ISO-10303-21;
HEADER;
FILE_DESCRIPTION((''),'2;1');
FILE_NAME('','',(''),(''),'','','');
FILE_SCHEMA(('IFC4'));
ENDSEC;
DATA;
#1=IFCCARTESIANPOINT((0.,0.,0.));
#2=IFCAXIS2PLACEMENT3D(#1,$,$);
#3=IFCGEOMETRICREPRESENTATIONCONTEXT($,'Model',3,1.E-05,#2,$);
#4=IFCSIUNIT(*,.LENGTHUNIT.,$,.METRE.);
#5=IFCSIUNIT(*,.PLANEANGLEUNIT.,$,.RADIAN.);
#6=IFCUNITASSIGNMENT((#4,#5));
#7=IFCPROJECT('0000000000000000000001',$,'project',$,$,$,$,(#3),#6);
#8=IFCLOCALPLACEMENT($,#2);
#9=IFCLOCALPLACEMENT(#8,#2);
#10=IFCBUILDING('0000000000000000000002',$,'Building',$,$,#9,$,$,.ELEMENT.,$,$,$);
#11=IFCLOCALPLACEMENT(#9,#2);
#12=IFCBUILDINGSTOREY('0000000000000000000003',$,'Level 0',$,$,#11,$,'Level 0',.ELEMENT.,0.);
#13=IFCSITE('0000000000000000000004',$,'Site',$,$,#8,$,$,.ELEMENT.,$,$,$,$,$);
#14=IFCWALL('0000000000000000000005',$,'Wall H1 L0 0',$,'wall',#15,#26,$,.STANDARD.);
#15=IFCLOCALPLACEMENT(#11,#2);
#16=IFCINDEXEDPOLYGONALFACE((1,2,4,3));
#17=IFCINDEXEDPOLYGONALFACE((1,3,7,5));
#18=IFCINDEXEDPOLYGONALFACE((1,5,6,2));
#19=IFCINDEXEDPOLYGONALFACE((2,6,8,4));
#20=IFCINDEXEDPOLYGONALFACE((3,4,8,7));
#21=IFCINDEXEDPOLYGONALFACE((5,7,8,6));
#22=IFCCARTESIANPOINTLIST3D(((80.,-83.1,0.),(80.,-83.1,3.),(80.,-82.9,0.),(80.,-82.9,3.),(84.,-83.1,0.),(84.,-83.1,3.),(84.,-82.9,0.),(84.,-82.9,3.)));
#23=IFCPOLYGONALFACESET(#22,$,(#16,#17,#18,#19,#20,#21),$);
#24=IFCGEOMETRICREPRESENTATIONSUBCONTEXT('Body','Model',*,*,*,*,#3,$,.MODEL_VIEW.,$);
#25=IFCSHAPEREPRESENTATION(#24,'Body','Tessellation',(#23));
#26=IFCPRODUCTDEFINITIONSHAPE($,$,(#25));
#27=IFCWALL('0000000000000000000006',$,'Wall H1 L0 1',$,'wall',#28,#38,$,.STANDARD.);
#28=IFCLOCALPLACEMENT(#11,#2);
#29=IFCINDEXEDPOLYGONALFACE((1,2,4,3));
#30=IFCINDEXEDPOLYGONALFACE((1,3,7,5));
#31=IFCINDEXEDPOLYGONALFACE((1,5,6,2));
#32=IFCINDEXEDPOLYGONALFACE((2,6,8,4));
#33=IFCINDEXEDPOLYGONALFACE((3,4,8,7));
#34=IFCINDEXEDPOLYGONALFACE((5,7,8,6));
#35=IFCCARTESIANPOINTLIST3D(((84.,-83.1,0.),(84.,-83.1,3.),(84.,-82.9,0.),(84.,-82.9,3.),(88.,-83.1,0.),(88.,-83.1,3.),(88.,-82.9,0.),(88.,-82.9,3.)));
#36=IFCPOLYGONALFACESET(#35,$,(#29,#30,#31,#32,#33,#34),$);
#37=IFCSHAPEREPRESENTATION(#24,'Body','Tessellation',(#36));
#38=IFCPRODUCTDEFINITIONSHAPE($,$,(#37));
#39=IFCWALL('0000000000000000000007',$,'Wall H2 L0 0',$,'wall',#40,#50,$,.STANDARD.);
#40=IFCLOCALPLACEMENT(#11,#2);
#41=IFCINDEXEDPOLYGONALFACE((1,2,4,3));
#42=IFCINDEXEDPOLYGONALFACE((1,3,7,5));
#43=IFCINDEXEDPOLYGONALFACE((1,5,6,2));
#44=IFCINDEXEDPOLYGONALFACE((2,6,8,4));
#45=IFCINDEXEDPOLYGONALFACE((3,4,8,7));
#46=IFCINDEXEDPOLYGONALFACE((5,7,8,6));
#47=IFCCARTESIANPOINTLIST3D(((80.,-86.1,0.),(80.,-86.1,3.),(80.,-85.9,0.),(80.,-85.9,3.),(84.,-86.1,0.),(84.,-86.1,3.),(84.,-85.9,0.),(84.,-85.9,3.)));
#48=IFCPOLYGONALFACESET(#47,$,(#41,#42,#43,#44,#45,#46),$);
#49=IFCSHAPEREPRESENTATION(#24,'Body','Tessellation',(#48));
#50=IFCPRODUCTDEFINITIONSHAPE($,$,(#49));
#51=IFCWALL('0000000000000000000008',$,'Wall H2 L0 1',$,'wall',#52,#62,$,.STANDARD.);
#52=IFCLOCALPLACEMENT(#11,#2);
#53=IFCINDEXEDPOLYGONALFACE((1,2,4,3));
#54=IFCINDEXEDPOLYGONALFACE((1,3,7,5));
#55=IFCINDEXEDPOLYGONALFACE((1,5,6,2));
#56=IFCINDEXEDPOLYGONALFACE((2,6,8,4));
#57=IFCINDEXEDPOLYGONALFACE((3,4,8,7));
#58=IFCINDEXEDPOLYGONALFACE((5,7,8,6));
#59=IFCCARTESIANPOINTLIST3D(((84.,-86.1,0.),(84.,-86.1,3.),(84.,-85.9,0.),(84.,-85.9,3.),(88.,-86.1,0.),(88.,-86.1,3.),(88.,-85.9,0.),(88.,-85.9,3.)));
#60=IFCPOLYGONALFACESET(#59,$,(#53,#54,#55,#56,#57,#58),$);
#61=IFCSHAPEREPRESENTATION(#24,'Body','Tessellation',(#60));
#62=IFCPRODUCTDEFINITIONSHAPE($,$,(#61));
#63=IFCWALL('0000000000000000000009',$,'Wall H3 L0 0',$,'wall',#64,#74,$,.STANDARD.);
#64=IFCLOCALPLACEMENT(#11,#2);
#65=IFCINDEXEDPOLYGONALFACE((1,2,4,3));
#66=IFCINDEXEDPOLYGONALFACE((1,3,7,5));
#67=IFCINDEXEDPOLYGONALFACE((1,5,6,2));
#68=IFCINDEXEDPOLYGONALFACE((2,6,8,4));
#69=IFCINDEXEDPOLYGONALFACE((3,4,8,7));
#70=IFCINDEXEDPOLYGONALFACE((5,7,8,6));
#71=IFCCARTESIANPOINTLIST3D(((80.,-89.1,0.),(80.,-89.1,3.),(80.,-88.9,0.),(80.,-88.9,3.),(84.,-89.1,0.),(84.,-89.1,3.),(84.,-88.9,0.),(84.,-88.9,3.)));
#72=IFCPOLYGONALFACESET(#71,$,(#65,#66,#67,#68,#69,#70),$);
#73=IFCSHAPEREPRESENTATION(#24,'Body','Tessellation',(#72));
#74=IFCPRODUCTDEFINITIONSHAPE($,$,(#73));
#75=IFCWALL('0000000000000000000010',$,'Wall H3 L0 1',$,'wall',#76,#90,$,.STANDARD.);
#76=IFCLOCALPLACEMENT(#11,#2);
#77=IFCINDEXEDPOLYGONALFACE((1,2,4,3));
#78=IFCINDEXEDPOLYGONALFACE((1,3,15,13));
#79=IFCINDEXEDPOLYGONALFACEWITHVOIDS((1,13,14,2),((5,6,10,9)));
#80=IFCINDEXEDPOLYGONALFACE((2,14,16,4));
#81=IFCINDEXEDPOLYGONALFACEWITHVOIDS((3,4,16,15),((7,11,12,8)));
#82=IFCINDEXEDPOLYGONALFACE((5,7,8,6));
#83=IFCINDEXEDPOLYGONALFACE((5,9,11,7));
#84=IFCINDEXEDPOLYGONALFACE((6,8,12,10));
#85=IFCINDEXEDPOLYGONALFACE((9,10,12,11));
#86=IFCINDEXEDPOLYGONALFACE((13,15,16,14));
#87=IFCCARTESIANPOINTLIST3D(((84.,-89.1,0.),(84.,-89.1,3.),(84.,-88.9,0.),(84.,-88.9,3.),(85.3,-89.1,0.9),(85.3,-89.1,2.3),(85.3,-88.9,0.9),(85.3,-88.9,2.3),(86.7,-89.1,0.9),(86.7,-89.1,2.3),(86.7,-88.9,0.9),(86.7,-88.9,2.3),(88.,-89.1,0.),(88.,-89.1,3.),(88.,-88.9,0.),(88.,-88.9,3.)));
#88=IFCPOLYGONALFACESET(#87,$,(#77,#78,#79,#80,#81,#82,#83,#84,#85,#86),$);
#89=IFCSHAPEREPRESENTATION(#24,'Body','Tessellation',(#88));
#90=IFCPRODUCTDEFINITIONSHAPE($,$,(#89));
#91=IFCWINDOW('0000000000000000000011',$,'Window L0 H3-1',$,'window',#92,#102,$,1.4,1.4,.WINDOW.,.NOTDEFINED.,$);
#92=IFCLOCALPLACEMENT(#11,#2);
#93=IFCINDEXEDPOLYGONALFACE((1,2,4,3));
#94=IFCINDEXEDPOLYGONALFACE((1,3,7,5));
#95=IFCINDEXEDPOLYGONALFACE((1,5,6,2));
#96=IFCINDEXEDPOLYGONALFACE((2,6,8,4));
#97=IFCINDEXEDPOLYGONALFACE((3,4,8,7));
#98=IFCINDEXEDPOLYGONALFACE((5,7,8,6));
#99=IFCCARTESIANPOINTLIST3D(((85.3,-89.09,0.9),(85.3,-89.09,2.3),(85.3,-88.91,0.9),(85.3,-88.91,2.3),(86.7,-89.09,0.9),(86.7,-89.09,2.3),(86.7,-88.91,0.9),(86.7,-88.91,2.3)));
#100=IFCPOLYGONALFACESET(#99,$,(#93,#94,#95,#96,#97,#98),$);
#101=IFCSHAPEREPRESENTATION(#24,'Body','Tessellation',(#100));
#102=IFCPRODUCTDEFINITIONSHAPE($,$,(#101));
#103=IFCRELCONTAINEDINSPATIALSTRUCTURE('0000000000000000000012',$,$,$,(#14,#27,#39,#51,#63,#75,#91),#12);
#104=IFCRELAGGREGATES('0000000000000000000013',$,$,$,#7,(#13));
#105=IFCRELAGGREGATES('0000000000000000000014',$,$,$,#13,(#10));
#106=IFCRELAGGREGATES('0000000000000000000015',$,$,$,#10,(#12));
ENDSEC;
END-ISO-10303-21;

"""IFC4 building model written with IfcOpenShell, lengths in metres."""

from ifc_helpers import new_model, si_unit, frame, frame_2d, origin, origin_2d, place, context, subcontext, project, spatial, rectangle, extrude, element, fill, save


model = new_model("IFC4")

# Units and contexts
model_context = context("Model", 3, precision=1e-05, world=origin())
body_context = subcontext(model_context, "Body", "Model", "MODEL_VIEW")
ifc_project = project(units=[si_unit("LENGTHUNIT", "METRE"), si_unit("PLANEANGLEUNIT", "RADIAN")], contexts=[model_context])

# Site, building, storey
site_placement = place(None, origin())
site = spatial("IfcSite", under=ifc_project, at=site_placement, Name="Site", CompositionType="ELEMENT")
building_placement = place(site_placement, origin())
building = spatial("IfcBuilding", under=site, at=building_placement, Name="Building", CompositionType="ELEMENT")
storey_placement = place(building_placement, origin())
storey = spatial("IfcBuildingStorey", under=building, at=storey_placement, Name="Level 0", LongName="Level 0", CompositionType="ELEMENT", Elevation=0.0)

# Walls
for number, where, z_axis, x_axis, name in (
    (1, (80.0, -83.0, 0.0), (0.0, 0.0, 1.0), (1.0, 0.0, 0.0), "Wall H1 L0 0"),
    (2, (84.0, -83.0, 0.0), (0.0, 0.0, 1.0), (1.0, 0.0, 0.0), "Wall H1 L0 1"),
    (3, (80.0, -86.0, 0.0), (0.0, 0.0, 1.0), (1.0, 0.0, 0.0), "Wall H2 L0 0"),
    (4, (84.0, -86.0, 0.0), (0.0, 0.0, 1.0), (1.0, 0.0, 0.0), "Wall H2 L0 1"),
    (5, (80.0, -89.0, 0.0), (0.0, 0.0, 1.0), (1.0, 0.0, 0.0), "Wall H3 L0 0"),
):
    element("IfcWall", number, at=place(storey_placement, frame(where, z_axis=z_axis, x_axis=x_axis)), inside=storey, Name=name, ObjectType="wall", PredefinedType="STANDARD", context=body_context, shape_type="SweptSolid", body=[
        extrude(rectangle(XDim=4.0, YDim=0.2, at=frame_2d((2.0, 0.0))), origin(), (0.0, 0.0, 1.0), 3.0),
    ])

# Wall, opening, window
wall_1_placement = place(storey_placement, frame((84.0, -89.0, 0.0), z_axis=(0.0, 0.0, 1.0), x_axis=(1.0, 0.0, 0.0)))
wall_1 = element("IfcWall", 6, at=wall_1_placement, inside=storey, Name="Wall H3 L0 1", ObjectType="wall", PredefinedType="STANDARD", context=body_context, shape_type="SweptSolid", body=[
    extrude(rectangle(XDim=4.0, YDim=0.2, at=frame_2d((2.0, 0.0))), origin(), (0.0, 0.0, 1.0), 3.0),
])
opening_1_placement = place(storey_placement, frame((86.0, -89.0, 0.9), z_axis=(0.0, 0.0, 1.0), x_axis=(1.0, 0.0, 0.0)))
opening_1 = element("IfcOpeningElement", 7, at=opening_1_placement, cuts=wall_1, ObjectType="Opening", PredefinedType="OPENING", context=body_context, shape_type="SweptSolid", body=[
    extrude(rectangle(XDim=1.4, YDim=0.22, at=origin_2d()), origin(), (0.0, 0.0, 1.0), 1.4),
])
window_1_placement = place(storey_placement, frame((86.0, -89.0, 0.9), z_axis=(0.0, 0.0, 1.0), x_axis=(1.0, 0.0, 0.0)))
window_1 = element("IfcWindow", 8, at=window_1_placement, inside=storey, Name="Window L0 H3-1", ObjectType="window", OverallHeight=1.4, OverallWidth=1.4, PartitioningType="NOTDEFINED", PredefinedType="WINDOW", context=body_context, shape_type="SweptSolid", body=[
    extrude(rectangle(XDim=1.4, YDim=0.18, at=origin_2d()), origin(), (0.0, 0.0, 1.0), 1.4),
])
fill(opening_1, window_1)

save(model, "model.ifc")
